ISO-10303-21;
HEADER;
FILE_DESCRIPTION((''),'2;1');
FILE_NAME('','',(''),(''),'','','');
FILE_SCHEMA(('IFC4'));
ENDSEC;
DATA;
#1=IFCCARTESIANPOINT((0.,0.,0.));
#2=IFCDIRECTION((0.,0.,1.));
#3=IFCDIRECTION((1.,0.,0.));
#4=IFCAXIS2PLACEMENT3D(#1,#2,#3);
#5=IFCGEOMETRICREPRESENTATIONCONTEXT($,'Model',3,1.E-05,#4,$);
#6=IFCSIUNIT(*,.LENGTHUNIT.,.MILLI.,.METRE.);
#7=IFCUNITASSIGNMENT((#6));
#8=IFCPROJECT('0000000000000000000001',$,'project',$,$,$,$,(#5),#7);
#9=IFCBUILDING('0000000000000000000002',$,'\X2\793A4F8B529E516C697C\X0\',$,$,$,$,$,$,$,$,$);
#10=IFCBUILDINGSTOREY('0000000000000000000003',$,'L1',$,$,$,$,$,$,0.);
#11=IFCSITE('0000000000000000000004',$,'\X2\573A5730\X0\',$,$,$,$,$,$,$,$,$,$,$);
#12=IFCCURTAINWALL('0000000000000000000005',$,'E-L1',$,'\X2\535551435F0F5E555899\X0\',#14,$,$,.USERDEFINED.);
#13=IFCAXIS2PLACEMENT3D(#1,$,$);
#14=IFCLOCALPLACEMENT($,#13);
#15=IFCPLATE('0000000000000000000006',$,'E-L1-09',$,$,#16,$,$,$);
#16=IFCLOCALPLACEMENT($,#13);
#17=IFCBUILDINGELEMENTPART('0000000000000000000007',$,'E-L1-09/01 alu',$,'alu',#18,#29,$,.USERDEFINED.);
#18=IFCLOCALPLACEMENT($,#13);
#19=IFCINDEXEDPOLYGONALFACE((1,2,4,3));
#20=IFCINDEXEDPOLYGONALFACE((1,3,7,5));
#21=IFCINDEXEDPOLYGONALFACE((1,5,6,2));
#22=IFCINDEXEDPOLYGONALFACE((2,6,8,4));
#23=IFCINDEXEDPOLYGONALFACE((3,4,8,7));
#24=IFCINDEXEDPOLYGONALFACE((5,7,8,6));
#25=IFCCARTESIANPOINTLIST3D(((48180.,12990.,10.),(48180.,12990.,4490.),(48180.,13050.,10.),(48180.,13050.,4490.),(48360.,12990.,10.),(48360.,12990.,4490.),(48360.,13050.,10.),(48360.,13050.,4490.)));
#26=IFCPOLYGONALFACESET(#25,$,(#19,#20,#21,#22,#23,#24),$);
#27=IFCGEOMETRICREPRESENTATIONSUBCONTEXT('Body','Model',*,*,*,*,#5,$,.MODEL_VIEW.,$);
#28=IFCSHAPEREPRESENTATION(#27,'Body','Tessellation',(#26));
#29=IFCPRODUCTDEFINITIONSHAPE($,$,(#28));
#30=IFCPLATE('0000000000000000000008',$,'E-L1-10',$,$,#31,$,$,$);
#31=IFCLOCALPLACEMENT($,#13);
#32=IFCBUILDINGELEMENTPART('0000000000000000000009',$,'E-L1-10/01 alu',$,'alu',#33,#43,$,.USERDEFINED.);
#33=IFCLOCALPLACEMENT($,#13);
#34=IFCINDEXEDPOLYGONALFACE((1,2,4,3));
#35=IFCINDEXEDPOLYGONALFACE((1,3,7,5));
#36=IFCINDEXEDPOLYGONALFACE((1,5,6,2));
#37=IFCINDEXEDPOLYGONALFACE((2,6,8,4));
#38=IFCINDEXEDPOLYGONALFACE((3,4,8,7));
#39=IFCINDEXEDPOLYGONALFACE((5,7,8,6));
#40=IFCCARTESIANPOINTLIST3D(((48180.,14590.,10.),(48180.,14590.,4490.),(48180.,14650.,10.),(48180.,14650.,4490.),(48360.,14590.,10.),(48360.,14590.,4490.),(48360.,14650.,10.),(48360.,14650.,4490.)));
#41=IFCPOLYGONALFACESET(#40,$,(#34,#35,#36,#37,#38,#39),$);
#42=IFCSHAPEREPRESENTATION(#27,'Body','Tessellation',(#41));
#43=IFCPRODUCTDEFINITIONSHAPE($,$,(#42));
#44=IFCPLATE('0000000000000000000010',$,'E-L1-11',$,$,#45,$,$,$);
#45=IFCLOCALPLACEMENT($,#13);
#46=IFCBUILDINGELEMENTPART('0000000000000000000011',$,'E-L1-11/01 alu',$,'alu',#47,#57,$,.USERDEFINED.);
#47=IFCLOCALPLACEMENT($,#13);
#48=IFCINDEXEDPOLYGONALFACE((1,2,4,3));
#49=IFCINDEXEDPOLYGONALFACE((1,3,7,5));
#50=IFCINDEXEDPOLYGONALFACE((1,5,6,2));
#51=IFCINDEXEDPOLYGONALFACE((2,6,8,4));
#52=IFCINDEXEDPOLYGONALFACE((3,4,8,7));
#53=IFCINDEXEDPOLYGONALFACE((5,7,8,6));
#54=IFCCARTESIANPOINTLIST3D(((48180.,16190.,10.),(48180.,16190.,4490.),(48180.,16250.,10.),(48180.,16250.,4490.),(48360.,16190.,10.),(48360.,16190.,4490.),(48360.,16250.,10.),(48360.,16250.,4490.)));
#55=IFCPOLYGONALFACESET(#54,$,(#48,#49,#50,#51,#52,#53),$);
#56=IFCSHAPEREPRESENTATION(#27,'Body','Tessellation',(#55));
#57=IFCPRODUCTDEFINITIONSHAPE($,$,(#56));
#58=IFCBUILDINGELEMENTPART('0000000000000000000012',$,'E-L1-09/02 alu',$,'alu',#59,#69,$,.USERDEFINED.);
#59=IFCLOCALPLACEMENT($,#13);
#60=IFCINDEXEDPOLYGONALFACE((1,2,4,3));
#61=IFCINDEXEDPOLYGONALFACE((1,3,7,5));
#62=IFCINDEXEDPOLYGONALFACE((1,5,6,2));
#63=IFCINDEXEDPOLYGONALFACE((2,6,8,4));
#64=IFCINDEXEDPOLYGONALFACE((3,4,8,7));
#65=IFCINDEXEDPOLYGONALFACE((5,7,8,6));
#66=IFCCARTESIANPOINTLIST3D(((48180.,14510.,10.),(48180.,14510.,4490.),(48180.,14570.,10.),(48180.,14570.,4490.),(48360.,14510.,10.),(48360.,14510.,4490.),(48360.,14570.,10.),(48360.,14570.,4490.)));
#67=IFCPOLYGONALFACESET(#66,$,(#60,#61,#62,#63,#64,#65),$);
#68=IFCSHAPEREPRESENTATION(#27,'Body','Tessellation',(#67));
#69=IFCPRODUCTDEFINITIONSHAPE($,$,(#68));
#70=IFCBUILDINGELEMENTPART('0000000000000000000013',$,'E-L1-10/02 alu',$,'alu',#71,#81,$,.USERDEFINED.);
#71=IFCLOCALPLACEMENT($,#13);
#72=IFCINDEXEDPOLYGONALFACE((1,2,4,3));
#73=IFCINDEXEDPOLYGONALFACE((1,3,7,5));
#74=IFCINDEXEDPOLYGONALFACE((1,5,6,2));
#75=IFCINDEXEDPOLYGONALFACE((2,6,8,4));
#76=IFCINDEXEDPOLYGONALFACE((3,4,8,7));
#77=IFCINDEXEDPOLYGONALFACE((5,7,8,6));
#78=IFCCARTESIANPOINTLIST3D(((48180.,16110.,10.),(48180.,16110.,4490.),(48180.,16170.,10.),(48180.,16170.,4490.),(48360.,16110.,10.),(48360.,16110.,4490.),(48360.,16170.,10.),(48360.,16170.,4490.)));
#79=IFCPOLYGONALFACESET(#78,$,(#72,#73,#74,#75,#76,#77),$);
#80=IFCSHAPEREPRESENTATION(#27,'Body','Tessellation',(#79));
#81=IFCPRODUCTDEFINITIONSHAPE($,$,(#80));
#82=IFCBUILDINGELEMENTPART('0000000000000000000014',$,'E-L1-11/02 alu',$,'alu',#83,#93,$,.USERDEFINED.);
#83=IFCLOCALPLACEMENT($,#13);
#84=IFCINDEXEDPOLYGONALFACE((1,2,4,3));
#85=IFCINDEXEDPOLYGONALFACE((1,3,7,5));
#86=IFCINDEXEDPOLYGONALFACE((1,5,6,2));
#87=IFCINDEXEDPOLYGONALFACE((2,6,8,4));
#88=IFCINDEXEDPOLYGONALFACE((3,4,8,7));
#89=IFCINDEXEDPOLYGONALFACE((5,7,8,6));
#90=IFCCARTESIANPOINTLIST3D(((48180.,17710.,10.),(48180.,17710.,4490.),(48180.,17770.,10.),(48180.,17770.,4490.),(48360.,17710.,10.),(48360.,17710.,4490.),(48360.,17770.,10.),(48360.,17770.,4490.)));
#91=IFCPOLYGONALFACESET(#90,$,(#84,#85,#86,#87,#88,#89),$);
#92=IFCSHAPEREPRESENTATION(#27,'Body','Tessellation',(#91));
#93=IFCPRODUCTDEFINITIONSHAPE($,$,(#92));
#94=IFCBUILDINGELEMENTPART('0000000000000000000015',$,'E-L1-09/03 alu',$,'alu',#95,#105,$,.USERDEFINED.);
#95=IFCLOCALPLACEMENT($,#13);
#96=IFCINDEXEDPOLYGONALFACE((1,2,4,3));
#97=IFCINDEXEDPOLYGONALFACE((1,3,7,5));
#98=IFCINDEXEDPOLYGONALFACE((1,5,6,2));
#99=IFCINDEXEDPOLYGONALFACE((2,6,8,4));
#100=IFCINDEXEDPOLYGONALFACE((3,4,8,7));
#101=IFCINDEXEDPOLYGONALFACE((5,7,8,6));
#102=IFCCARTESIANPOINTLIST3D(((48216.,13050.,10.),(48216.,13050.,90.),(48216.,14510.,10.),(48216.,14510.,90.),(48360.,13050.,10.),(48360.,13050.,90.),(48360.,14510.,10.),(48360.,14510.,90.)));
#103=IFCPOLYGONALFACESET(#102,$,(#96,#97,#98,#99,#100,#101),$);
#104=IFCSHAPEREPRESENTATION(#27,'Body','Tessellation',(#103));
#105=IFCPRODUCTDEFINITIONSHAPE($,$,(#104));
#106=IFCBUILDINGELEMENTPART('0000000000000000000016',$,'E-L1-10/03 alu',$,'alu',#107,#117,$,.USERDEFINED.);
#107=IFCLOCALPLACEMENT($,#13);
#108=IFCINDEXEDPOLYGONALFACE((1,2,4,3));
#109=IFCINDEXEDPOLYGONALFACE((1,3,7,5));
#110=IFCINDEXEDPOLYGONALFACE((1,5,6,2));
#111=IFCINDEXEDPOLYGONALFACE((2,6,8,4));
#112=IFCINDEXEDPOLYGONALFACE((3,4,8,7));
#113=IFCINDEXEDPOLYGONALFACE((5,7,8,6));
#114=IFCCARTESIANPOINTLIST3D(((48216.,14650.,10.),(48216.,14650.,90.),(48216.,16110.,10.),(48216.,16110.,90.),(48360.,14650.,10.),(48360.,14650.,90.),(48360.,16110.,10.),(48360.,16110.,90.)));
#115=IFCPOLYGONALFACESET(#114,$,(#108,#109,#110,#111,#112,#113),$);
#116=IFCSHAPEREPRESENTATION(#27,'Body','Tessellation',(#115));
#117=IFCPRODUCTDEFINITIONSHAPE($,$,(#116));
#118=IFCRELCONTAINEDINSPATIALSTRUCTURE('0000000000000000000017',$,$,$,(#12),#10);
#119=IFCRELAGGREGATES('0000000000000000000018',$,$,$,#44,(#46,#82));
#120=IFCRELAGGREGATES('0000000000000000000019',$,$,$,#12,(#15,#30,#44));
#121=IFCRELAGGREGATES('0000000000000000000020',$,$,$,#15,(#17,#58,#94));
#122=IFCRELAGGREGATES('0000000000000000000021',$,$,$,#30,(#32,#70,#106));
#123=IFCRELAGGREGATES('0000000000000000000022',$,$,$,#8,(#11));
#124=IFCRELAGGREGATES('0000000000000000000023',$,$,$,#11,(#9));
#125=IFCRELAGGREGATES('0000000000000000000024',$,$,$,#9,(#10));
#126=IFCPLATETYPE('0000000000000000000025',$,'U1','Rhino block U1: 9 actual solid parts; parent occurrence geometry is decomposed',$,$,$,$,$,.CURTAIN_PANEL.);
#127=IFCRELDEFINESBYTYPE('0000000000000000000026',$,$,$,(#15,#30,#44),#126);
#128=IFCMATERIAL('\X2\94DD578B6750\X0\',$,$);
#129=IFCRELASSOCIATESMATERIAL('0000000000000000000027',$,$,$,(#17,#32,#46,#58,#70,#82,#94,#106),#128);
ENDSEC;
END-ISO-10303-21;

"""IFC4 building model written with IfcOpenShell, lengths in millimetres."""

from ifc_helpers import new_model, si_unit, frame, frame_2d, origin, origin_with_axes, place, context, subcontext, project, spatial, rectangle, extrude, source, transform, mapped, material, type_object, element, aggregate, save


model = new_model("IFC4")

# Units and contexts
model_context = context("Model", 3, precision=1e-05, world=origin_with_axes())
body_context = subcontext(model_context, "Body", "Model", "MODEL_VIEW")
ifc_project = project(units=[si_unit("LENGTHUNIT", "METRE", prefix="MILLI")], contexts=[model_context])

# Site, building, storey
site = spatial("IfcSite", under=ifc_project, Name="场地")
building = spatial("IfcBuilding", under=site, Name="示例办公楼")
storey = spatial("IfcBuildingStorey", under=building, Name="L1", Elevation=0.0)

# Curtain wall, plates, building element parts
curtain_wall = element("IfcCurtainWall", 1, inside=storey, Name="E-L1", ObjectType="单元式幕墙", PredefinedType="USERDEFINED")
plate_type = type_object("IfcPlateType", Name="U1", Description="Rhino block U1: 9 actual solid parts; parent occurrence geometry is decomposed", PredefinedType="CURTAIN_PANEL")
plate_1_placement = place(None, frame((48360.0, 12990.0, 10.0), z_axis=(0.0, 0.0, 1.0), x_axis=(0.0, 1.0, 0.0)))
plate_1 = element("IfcPlate", 2, at=plate_1_placement, type_object=plate_type, Name="E-L1-09")
ifc_material_1 = material(Name="铝型材")
shared_shape_1 = source(origin(), body_context, "Body", "SweptSolid", [
    extrude(rectangle(XDim=60.0, YDim=180.0, at=frame_2d((30.0, 90.0))), origin(), (0.0, 0.0, 1.0), 4480.0),
])
building_element_part_1_placement = place(plate_1_placement, origin())
building_element_part_1 = element("IfcBuildingElementPart", 3, at=building_element_part_1_placement, material=ifc_material_1, Name="E-L1-09/01 alu", ObjectType="alu", PredefinedType="USERDEFINED", context=body_context, shape_type="MappedRepresentation", body=[
    mapped(shared_shape_1, transform((0.0, 0.0, 0.0))),
])
plate_2_placement = place(None, frame((48360.0, 14590.0, 10.0), z_axis=(0.0, 0.0, 1.0), x_axis=(0.0, 1.0, 0.0)))
plate_2 = element("IfcPlate", 4, at=plate_2_placement, type_object=plate_type, Name="E-L1-10")
building_element_part_2_placement = place(plate_2_placement, origin())
building_element_part_2 = element("IfcBuildingElementPart", 5, at=building_element_part_2_placement, material=ifc_material_1, Name="E-L1-10/01 alu", ObjectType="alu", PredefinedType="USERDEFINED", context=body_context, shape_type="MappedRepresentation", body=[
    mapped(shared_shape_1, transform((0.0, 0.0, 0.0))),
])
plate_3_placement = place(None, frame((48360.0, 16190.0, 10.0), z_axis=(0.0, 0.0, 1.0), x_axis=(0.0, 1.0, 0.0)))
plate_3 = element("IfcPlate", 6, at=plate_3_placement, type_object=plate_type, Name="E-L1-11")
building_element_part_3_placement = place(plate_3_placement, origin())
building_element_part_3 = element("IfcBuildingElementPart", 7, at=building_element_part_3_placement, material=ifc_material_1, Name="E-L1-11/01 alu", ObjectType="alu", PredefinedType="USERDEFINED", context=body_context, shape_type="MappedRepresentation", body=[
    mapped(shared_shape_1, transform((0.0, 0.0, 0.0))),
])
shared_shape_2 = source(origin(), body_context, "Body", "SweptSolid", [
    extrude(rectangle(XDim=60.0, YDim=180.0, at=frame_2d((1550.0, 90.0))), origin(), (0.0, 0.0, 1.0), 4480.0),
])
building_element_part_4_placement = place(plate_1_placement, origin())
building_element_part_4 = element("IfcBuildingElementPart", 8, at=building_element_part_4_placement, material=ifc_material_1, Name="E-L1-09/02 alu", ObjectType="alu", PredefinedType="USERDEFINED", context=body_context, shape_type="MappedRepresentation", body=[
    mapped(shared_shape_2, transform((0.0, 0.0, 0.0))),
])
building_element_part_5_placement = place(plate_2_placement, origin())
building_element_part_5 = element("IfcBuildingElementPart", 9, at=building_element_part_5_placement, material=ifc_material_1, Name="E-L1-10/02 alu", ObjectType="alu", PredefinedType="USERDEFINED", context=body_context, shape_type="MappedRepresentation", body=[
    mapped(shared_shape_2, transform((0.0, 0.0, 0.0))),
])
building_element_part_6_placement = place(plate_3_placement, origin())
building_element_part_6 = element("IfcBuildingElementPart", 10, at=building_element_part_6_placement, material=ifc_material_1, Name="E-L1-11/02 alu", ObjectType="alu", PredefinedType="USERDEFINED", context=body_context, shape_type="MappedRepresentation", body=[
    mapped(shared_shape_2, transform((0.0, 0.0, 0.0))),
])
aggregate(plate_3, [building_element_part_3, building_element_part_6])
shared_shape_3 = source(origin(), body_context, "Body", "SweptSolid", [
    extrude(rectangle(XDim=1460.0, YDim=144.0, at=frame_2d((790.0, 72.0))), origin(), (0.0, 0.0, 1.0), 80.0),
])
building_element_part_7_placement = place(plate_1_placement, origin())
building_element_part_7 = element("IfcBuildingElementPart", 11, at=building_element_part_7_placement, material=ifc_material_1, Name="E-L1-09/03 alu", ObjectType="alu", PredefinedType="USERDEFINED", context=body_context, shape_type="MappedRepresentation", body=[
    mapped(shared_shape_3, transform((0.0, 0.0, 0.0))),
])
building_element_part_8_placement = place(plate_2_placement, origin())
building_element_part_8 = element("IfcBuildingElementPart", 12, at=building_element_part_8_placement, material=ifc_material_1, Name="E-L1-10/03 alu", ObjectType="alu", PredefinedType="USERDEFINED", context=body_context, shape_type="MappedRepresentation", body=[
    mapped(shared_shape_3, transform((0.0, 0.0, 0.0))),
])
aggregate(curtain_wall, [plate_1, plate_2, plate_3])
aggregate(plate_1, [building_element_part_1, building_element_part_4, building_element_part_7])
aggregate(plate_2, [building_element_part_2, building_element_part_5, building_element_part_8])

save(model, "model.ifc")
